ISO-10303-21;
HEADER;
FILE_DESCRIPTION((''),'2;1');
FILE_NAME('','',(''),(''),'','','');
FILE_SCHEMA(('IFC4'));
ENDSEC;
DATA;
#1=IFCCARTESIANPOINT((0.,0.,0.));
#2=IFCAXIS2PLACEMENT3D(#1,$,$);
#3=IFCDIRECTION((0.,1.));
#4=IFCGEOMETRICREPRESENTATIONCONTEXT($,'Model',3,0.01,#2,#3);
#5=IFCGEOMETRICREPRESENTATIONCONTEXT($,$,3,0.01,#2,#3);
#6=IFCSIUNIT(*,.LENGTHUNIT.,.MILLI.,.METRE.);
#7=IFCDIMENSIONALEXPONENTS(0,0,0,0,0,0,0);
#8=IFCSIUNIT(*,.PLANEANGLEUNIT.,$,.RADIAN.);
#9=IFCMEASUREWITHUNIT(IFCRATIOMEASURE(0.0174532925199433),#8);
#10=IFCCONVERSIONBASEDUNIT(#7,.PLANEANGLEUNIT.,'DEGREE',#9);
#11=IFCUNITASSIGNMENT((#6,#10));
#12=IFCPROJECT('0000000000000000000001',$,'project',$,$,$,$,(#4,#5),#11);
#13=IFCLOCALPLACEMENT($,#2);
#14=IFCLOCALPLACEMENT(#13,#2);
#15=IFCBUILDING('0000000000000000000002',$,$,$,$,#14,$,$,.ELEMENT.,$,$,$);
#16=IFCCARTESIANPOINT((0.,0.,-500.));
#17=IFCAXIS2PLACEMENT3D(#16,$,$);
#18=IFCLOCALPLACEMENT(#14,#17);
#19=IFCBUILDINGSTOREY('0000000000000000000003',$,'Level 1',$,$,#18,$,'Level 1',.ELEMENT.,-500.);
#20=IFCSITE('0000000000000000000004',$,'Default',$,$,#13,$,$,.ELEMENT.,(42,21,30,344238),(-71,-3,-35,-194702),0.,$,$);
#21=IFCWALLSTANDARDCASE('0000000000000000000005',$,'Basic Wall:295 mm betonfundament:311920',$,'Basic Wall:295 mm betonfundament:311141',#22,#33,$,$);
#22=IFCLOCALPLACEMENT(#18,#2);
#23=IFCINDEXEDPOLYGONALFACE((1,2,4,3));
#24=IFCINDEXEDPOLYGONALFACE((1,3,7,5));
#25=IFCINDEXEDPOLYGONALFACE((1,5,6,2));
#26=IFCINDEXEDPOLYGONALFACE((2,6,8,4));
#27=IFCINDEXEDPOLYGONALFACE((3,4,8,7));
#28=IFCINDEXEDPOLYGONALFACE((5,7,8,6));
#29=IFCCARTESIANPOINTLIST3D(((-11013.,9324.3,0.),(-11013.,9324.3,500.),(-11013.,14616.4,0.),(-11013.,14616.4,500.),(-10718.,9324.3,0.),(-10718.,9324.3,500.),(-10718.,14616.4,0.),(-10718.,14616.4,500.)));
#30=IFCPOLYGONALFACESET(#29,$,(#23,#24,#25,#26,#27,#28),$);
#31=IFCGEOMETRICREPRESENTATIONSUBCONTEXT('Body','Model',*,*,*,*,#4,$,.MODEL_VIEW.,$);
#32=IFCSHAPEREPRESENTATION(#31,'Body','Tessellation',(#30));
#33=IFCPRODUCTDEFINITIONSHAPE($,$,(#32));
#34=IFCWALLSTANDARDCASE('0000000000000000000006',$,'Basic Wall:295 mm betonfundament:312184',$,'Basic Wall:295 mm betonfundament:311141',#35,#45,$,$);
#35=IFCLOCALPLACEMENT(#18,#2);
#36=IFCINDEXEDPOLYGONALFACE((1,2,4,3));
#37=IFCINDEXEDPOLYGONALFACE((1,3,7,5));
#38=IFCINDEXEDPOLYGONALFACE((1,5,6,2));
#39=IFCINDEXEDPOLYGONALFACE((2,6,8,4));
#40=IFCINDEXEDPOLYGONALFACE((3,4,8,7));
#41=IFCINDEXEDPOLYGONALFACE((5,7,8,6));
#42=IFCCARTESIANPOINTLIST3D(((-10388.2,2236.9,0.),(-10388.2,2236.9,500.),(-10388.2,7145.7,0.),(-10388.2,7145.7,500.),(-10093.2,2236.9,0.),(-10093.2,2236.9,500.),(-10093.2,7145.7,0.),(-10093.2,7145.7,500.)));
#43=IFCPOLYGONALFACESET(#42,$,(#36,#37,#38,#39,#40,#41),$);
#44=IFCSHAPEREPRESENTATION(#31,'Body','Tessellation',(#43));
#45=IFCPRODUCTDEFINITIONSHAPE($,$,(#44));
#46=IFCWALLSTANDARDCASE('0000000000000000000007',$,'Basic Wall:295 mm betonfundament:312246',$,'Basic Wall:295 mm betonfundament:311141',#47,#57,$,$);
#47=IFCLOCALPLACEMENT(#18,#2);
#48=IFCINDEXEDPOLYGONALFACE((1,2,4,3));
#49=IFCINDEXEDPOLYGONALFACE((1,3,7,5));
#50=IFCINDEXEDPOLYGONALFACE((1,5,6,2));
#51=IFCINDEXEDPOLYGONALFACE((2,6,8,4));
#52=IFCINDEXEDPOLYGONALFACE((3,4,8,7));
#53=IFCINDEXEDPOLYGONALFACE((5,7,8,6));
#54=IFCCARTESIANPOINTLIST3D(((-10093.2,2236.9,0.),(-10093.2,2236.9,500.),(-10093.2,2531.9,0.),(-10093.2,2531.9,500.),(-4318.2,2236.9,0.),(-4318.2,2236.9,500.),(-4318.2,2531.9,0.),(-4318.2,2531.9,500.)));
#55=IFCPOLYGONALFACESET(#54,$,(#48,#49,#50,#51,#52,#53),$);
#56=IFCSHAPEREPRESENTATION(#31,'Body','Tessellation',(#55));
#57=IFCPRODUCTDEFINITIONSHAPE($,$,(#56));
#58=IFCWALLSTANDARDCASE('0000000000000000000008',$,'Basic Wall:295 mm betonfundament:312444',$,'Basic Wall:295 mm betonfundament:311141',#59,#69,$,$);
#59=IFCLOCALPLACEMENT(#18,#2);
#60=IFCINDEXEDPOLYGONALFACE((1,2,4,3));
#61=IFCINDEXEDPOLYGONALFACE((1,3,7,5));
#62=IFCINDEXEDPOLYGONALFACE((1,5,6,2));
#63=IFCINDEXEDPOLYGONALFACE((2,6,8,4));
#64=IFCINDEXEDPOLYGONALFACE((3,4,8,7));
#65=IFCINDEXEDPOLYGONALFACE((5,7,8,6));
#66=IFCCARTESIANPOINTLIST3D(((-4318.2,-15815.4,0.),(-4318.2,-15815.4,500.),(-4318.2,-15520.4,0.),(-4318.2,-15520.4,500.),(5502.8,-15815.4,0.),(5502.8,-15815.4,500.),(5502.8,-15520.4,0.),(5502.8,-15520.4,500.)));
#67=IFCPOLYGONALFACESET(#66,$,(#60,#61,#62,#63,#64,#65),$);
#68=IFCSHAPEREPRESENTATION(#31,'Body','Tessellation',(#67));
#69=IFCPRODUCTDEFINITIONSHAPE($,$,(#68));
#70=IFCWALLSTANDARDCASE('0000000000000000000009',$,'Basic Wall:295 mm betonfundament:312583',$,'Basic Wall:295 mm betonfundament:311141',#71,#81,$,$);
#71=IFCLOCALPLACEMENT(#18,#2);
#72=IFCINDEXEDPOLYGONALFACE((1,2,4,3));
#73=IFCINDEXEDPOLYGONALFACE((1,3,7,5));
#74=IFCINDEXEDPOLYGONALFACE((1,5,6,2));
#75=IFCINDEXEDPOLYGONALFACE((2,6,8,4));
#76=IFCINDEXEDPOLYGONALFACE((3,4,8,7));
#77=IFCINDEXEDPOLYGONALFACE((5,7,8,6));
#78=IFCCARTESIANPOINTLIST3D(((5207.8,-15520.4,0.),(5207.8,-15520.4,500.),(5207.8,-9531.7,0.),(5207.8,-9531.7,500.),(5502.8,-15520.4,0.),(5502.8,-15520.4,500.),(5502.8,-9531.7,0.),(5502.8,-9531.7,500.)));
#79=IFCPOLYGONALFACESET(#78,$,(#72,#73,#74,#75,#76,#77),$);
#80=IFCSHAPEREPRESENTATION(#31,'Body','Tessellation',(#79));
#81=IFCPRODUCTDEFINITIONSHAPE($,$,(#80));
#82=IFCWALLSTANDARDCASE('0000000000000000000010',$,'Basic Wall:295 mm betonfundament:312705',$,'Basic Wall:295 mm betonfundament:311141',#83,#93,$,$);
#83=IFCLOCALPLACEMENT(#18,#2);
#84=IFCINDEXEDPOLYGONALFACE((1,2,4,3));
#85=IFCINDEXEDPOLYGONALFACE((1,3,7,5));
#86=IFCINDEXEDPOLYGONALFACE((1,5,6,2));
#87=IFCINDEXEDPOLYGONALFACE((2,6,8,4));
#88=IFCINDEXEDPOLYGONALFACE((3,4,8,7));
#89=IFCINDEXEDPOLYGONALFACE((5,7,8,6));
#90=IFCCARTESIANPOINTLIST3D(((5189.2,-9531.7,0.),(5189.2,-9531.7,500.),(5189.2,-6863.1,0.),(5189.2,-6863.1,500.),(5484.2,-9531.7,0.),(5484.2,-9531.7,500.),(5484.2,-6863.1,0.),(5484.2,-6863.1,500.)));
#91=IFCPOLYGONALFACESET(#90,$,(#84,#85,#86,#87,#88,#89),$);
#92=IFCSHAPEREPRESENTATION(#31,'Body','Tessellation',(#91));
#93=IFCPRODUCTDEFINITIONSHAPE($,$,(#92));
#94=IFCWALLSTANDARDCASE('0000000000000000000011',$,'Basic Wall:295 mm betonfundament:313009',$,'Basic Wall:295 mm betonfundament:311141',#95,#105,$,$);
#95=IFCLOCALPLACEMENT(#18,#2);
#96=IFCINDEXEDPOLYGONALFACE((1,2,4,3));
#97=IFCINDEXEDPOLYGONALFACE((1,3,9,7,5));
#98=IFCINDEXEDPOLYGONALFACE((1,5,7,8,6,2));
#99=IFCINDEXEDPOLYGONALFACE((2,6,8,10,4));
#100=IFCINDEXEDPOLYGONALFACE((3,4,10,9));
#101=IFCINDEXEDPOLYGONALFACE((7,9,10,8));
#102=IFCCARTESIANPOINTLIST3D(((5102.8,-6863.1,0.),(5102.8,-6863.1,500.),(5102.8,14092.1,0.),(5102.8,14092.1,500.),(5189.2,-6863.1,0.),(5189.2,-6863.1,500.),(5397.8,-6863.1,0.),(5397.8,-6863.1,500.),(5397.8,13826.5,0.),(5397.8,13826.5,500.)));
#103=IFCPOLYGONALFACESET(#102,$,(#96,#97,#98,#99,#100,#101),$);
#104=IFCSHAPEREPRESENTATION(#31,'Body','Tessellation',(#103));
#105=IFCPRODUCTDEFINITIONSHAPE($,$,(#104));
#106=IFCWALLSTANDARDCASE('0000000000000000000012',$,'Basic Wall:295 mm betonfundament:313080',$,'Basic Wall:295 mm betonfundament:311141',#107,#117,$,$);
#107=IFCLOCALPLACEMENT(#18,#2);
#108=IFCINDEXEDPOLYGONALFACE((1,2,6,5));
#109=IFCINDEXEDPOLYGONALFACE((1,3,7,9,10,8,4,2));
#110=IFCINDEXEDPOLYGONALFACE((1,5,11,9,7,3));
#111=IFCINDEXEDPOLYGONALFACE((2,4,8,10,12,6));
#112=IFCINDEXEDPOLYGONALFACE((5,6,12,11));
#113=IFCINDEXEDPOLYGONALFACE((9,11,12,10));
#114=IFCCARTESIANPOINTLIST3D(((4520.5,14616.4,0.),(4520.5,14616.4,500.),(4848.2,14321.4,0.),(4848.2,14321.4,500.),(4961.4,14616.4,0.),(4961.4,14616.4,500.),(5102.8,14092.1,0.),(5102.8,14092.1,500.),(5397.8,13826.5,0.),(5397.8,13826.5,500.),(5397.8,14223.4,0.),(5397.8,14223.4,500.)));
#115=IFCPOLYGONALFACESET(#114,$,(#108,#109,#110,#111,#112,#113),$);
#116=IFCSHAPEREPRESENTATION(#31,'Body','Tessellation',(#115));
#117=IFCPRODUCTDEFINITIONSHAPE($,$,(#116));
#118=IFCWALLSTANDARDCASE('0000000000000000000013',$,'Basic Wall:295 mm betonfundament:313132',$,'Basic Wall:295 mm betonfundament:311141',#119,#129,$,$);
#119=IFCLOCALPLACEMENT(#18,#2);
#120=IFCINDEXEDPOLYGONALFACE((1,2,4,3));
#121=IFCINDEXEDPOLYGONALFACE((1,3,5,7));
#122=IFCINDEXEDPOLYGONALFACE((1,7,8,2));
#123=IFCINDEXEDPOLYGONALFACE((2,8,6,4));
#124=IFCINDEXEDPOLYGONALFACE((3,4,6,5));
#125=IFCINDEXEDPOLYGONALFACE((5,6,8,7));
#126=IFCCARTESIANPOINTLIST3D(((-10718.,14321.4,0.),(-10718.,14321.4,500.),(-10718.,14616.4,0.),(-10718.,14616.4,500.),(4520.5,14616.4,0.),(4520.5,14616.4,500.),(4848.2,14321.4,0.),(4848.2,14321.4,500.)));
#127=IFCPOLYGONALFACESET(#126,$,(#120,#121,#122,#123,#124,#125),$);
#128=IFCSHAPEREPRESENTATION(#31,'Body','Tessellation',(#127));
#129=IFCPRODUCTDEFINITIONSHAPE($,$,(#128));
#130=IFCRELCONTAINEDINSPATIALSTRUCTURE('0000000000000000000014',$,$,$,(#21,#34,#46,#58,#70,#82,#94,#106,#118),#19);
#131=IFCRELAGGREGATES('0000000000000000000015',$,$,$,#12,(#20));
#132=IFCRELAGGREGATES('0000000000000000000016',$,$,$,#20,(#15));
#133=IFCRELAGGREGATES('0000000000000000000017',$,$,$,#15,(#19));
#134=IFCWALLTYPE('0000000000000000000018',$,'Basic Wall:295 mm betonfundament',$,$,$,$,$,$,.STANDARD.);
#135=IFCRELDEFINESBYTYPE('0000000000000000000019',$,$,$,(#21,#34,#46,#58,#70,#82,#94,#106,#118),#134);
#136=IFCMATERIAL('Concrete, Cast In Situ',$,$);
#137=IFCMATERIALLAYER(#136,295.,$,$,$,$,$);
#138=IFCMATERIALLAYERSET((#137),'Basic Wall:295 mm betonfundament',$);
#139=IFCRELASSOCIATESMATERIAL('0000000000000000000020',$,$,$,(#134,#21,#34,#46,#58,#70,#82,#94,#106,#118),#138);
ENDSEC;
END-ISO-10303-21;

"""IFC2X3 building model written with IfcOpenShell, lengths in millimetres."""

from ifc_helpers import new_model, entity, si_unit, converted_unit, direction, frame, frame_2d, origin, place, context, subcontext, project, spatial, polyline, rectangle, outline, extrude, material, layer, layer_set, layer_usage, type_object, element, save


model = new_model("IFC2X3")

# Units and contexts
model_context = context("Model", 3, precision=0.01, world=origin(), true_north=direction((0.0, 1.0)))
context_of_model = context(None, 3, precision=0.01, world=origin(), true_north=direction((0.0, 1.0)))
body_context = subcontext(model_context, "Body", "Model", "MODEL_VIEW")
ifc_project = project(units=[si_unit("LENGTHUNIT", "METRE", prefix="MILLI"), converted_unit("PLANEANGLEUNIT", "DEGREE", entity("IfcRatioMeasure", 0.0174532925199433), si_unit("PLANEANGLEUNIT", "RADIAN"), dimensions=[0, 0, 0, 0, 0, 0, 0])], contexts=[model_context, context_of_model])

# Site, building, storey
site_placement = place(None, origin())
site = spatial("IfcSite", under=ifc_project, at=site_placement, Name="Default", CompositionType="ELEMENT", RefLatitude=(42, 21, 30, 344238), RefLongitude=(-71, -3, -35, -194702), RefElevation=0.0)
building_placement = place(site_placement, origin())
building = spatial("IfcBuilding", under=site, at=building_placement, CompositionType="ELEMENT")
storey_placement = place(building_placement, frame((0.0, 0.0, -500.0)))
storey = spatial("IfcBuildingStorey", under=building, at=storey_placement, Name="Level 1", LongName="Level 1", CompositionType="ELEMENT", Elevation=-500.0)

# Wall
ifc_material = material(Name="Concrete, Cast In Situ")
ifc_layer = layer(ifc_material, 295.0)
ifc_layer_set = layer_set([ifc_layer], Name="Basic Wall:295 mm betonfundament")
ifc_layer_usage_1 = layer_usage(ifc_layer_set, "AXIS2", "NEGATIVE", 147.5)
wall_type = type_object("IfcWallType", Name="Basic Wall:295 mm betonfundament", PredefinedType="STANDARD", material=ifc_layer_set)
wall_1_placement = place(storey_placement, frame((-10865.5, 14616.4, 0.0), z_axis=(0.0, 0.0, 1.0), x_axis=(0.0, -1.0, 0.0)))
element("IfcWallStandardCase", 1, at=wall_1_placement, inside=storey, type_object=wall_type, material=ifc_layer_usage_1, Name="Basic Wall:295 mm betonfundament:311920", ObjectType="Basic Wall:295 mm betonfundament:311141", context=body_context, shape_type="SweptSolid", body=[
    extrude(rectangle(XDim=5292.1, YDim=295.0, at=frame_2d((2646.0, 0.0), x_axis=(-1.0, 0.0))), origin(), (0.0, 0.0, 1.0), 500.0),
])

# Walls
ifc_layer_usage_2 = layer_usage(ifc_layer_set, "AXIS2", "NEGATIVE", 147.5)
wall_2_placement = place(storey_placement, frame((-10240.7, 7145.7, 0.0), z_axis=(0.0, 0.0, 1.0), x_axis=(0.0, -1.0, 0.0)))
element("IfcWallStandardCase", 2, at=wall_2_placement, inside=storey, type_object=wall_type, material=ifc_layer_usage_2, Name="Basic Wall:295 mm betonfundament:312184", ObjectType="Basic Wall:295 mm betonfundament:311141", context=body_context, shape_type="SweptSolid", body=[
    extrude(rectangle(XDim=4908.8, YDim=295.0, at=frame_2d((2454.4, 0.0), x_axis=(-1.0, 0.0))), origin(), (0.0, 0.0, 1.0), 500.0),
])
ifc_layer_usage_3 = layer_usage(ifc_layer_set, "AXIS2", "NEGATIVE", 147.5)
wall_3_placement = place(storey_placement, frame((-10093.2, 2384.4, 0.0)))
element("IfcWallStandardCase", 3, at=wall_3_placement, inside=storey, type_object=wall_type, material=ifc_layer_usage_3, Name="Basic Wall:295 mm betonfundament:312246", ObjectType="Basic Wall:295 mm betonfundament:311141", context=body_context, shape_type="SweptSolid", body=[
    extrude(rectangle(XDim=5775.0, YDim=295.0, at=frame_2d((2887.5, 0.0), x_axis=(-1.0, 0.0))), origin(), (0.0, 0.0, 1.0), 500.0),
])

# Walls
ifc_layer_usage_4 = layer_usage(ifc_layer_set, "AXIS2", "NEGATIVE", 147.5)
wall_4_placement = place(storey_placement, frame((-4318.2, -15667.9, 0.0)))
element("IfcWallStandardCase", 4, at=wall_4_placement, inside=storey, type_object=wall_type, material=ifc_layer_usage_4, Name="Basic Wall:295 mm betonfundament:312444", ObjectType="Basic Wall:295 mm betonfundament:311141", context=body_context, shape_type="SweptSolid", body=[
    extrude(rectangle(XDim=9821.1, YDim=295.0, at=frame_2d((4910.5, 0.0), x_axis=(-1.0, 0.0))), origin(), (0.0, 0.0, 1.0), 500.0),
])
ifc_layer_usage_5 = layer_usage(ifc_layer_set, "AXIS2", "NEGATIVE", 147.5)
wall_5_placement = place(storey_placement, frame((5355.3, -15520.4, 0.0), z_axis=(0.0, 0.0, 1.0), x_axis=(0.0, 1.0, 0.0)))
element("IfcWallStandardCase", 5, at=wall_5_placement, inside=storey, type_object=wall_type, material=ifc_layer_usage_5, Name="Basic Wall:295 mm betonfundament:312583", ObjectType="Basic Wall:295 mm betonfundament:311141", context=body_context, shape_type="SweptSolid", body=[
    extrude(rectangle(XDim=5988.7, YDim=295.0, at=frame_2d((2994.4, 0.0), x_axis=(-1.0, 0.0))), origin(), (0.0, 0.0, 1.0), 500.0),
])
ifc_layer_usage_6 = layer_usage(ifc_layer_set, "AXIS2", "NEGATIVE", 147.5)
wall_6_placement = place(storey_placement, frame((5336.7, -9531.7, 0.0), z_axis=(0.0, 0.0, 1.0), x_axis=(0.0, 1.0, 0.0)))
element("IfcWallStandardCase", 6, at=wall_6_placement, inside=storey, type_object=wall_type, material=ifc_layer_usage_6, Name="Basic Wall:295 mm betonfundament:312705", ObjectType="Basic Wall:295 mm betonfundament:311141", context=body_context, shape_type="SweptSolid", body=[
    extrude(rectangle(XDim=2668.6, YDim=295.0, at=frame_2d((1334.3, 0.0), x_axis=(-1.0, 0.0))), origin(), (0.0, 0.0, 1.0), 500.0),
])
ifc_layer_usage_7 = layer_usage(ifc_layer_set, "AXIS2", "NEGATIVE", 147.5)
wall_7_placement = place(storey_placement, frame((5250.3, -6863.1, 0.0), z_axis=(0.0, 0.0, 1.0), x_axis=(0.0, 1.0, 0.0)))
element("IfcWallStandardCase", 7, at=wall_7_placement, inside=storey, type_object=wall_type, material=ifc_layer_usage_7, Name="Basic Wall:295 mm betonfundament:313009", ObjectType="Basic Wall:295 mm betonfundament:311141", context=body_context, shape_type="SweptSolid", body=[
    extrude(outline(polyline([(20689.6, -147.5), (20955.2, 147.5), (0.0, 147.5), (0.0, 61.1), (0.0, -147.5), (20689.6, -147.5)])), origin(), (0.0, 0.0, 1.0), 500.0),
])
ifc_layer_usage_8 = layer_usage(ifc_layer_set, "AXIS2", "NEGATIVE", 147.5)
wall_8_placement = place(storey_placement, frame((5496.5, 13936.1, 0.0), z_axis=(0.0, 0.0, 1.0), x_axis=(-0.743145, 0.669131, 0.0)))
element("IfcWallStandardCase", 8, at=wall_8_placement, inside=storey, type_object=wall_type, material=ifc_layer_usage_8, Name="Basic Wall:295 mm betonfundament:313080", ObjectType="Basic Wall:295 mm betonfundament:311141", context=body_context, shape_type="SweptSolid", body=[
    extrude(outline(polyline([(852.9, -147.5), (1180.5, 147.5), (739.7, 147.5), (397.0, 147.5), (0.0, 147.5), (265.6, -147.5), (852.9, -147.5)])), origin(), (0.0, 0.0, 1.0), 500.0),
])
ifc_layer_usage_9 = layer_usage(ifc_layer_set, "AXIS2", "NEGATIVE", 147.5)
wall_9_placement = place(storey_placement, frame((4848.2, 14468.9, 0.0), z_axis=(0.0, 0.0, 1.0), x_axis=(-1.0, 0.0, 0.0)))
element("IfcWallStandardCase", 9, at=wall_9_placement, inside=storey, type_object=wall_type, material=ifc_layer_usage_9, Name="Basic Wall:295 mm betonfundament:313132", ObjectType="Basic Wall:295 mm betonfundament:311141", context=body_context, shape_type="SweptSolid", body=[
    extrude(outline(polyline([(15566.1, -147.5), (15566.1, 147.5), (0.0, 147.5), (327.6, -147.5), (15566.1, -147.5)])), origin(), (0.0, 0.0, 1.0), 500.0),
])

save(model, "model.ifc")
